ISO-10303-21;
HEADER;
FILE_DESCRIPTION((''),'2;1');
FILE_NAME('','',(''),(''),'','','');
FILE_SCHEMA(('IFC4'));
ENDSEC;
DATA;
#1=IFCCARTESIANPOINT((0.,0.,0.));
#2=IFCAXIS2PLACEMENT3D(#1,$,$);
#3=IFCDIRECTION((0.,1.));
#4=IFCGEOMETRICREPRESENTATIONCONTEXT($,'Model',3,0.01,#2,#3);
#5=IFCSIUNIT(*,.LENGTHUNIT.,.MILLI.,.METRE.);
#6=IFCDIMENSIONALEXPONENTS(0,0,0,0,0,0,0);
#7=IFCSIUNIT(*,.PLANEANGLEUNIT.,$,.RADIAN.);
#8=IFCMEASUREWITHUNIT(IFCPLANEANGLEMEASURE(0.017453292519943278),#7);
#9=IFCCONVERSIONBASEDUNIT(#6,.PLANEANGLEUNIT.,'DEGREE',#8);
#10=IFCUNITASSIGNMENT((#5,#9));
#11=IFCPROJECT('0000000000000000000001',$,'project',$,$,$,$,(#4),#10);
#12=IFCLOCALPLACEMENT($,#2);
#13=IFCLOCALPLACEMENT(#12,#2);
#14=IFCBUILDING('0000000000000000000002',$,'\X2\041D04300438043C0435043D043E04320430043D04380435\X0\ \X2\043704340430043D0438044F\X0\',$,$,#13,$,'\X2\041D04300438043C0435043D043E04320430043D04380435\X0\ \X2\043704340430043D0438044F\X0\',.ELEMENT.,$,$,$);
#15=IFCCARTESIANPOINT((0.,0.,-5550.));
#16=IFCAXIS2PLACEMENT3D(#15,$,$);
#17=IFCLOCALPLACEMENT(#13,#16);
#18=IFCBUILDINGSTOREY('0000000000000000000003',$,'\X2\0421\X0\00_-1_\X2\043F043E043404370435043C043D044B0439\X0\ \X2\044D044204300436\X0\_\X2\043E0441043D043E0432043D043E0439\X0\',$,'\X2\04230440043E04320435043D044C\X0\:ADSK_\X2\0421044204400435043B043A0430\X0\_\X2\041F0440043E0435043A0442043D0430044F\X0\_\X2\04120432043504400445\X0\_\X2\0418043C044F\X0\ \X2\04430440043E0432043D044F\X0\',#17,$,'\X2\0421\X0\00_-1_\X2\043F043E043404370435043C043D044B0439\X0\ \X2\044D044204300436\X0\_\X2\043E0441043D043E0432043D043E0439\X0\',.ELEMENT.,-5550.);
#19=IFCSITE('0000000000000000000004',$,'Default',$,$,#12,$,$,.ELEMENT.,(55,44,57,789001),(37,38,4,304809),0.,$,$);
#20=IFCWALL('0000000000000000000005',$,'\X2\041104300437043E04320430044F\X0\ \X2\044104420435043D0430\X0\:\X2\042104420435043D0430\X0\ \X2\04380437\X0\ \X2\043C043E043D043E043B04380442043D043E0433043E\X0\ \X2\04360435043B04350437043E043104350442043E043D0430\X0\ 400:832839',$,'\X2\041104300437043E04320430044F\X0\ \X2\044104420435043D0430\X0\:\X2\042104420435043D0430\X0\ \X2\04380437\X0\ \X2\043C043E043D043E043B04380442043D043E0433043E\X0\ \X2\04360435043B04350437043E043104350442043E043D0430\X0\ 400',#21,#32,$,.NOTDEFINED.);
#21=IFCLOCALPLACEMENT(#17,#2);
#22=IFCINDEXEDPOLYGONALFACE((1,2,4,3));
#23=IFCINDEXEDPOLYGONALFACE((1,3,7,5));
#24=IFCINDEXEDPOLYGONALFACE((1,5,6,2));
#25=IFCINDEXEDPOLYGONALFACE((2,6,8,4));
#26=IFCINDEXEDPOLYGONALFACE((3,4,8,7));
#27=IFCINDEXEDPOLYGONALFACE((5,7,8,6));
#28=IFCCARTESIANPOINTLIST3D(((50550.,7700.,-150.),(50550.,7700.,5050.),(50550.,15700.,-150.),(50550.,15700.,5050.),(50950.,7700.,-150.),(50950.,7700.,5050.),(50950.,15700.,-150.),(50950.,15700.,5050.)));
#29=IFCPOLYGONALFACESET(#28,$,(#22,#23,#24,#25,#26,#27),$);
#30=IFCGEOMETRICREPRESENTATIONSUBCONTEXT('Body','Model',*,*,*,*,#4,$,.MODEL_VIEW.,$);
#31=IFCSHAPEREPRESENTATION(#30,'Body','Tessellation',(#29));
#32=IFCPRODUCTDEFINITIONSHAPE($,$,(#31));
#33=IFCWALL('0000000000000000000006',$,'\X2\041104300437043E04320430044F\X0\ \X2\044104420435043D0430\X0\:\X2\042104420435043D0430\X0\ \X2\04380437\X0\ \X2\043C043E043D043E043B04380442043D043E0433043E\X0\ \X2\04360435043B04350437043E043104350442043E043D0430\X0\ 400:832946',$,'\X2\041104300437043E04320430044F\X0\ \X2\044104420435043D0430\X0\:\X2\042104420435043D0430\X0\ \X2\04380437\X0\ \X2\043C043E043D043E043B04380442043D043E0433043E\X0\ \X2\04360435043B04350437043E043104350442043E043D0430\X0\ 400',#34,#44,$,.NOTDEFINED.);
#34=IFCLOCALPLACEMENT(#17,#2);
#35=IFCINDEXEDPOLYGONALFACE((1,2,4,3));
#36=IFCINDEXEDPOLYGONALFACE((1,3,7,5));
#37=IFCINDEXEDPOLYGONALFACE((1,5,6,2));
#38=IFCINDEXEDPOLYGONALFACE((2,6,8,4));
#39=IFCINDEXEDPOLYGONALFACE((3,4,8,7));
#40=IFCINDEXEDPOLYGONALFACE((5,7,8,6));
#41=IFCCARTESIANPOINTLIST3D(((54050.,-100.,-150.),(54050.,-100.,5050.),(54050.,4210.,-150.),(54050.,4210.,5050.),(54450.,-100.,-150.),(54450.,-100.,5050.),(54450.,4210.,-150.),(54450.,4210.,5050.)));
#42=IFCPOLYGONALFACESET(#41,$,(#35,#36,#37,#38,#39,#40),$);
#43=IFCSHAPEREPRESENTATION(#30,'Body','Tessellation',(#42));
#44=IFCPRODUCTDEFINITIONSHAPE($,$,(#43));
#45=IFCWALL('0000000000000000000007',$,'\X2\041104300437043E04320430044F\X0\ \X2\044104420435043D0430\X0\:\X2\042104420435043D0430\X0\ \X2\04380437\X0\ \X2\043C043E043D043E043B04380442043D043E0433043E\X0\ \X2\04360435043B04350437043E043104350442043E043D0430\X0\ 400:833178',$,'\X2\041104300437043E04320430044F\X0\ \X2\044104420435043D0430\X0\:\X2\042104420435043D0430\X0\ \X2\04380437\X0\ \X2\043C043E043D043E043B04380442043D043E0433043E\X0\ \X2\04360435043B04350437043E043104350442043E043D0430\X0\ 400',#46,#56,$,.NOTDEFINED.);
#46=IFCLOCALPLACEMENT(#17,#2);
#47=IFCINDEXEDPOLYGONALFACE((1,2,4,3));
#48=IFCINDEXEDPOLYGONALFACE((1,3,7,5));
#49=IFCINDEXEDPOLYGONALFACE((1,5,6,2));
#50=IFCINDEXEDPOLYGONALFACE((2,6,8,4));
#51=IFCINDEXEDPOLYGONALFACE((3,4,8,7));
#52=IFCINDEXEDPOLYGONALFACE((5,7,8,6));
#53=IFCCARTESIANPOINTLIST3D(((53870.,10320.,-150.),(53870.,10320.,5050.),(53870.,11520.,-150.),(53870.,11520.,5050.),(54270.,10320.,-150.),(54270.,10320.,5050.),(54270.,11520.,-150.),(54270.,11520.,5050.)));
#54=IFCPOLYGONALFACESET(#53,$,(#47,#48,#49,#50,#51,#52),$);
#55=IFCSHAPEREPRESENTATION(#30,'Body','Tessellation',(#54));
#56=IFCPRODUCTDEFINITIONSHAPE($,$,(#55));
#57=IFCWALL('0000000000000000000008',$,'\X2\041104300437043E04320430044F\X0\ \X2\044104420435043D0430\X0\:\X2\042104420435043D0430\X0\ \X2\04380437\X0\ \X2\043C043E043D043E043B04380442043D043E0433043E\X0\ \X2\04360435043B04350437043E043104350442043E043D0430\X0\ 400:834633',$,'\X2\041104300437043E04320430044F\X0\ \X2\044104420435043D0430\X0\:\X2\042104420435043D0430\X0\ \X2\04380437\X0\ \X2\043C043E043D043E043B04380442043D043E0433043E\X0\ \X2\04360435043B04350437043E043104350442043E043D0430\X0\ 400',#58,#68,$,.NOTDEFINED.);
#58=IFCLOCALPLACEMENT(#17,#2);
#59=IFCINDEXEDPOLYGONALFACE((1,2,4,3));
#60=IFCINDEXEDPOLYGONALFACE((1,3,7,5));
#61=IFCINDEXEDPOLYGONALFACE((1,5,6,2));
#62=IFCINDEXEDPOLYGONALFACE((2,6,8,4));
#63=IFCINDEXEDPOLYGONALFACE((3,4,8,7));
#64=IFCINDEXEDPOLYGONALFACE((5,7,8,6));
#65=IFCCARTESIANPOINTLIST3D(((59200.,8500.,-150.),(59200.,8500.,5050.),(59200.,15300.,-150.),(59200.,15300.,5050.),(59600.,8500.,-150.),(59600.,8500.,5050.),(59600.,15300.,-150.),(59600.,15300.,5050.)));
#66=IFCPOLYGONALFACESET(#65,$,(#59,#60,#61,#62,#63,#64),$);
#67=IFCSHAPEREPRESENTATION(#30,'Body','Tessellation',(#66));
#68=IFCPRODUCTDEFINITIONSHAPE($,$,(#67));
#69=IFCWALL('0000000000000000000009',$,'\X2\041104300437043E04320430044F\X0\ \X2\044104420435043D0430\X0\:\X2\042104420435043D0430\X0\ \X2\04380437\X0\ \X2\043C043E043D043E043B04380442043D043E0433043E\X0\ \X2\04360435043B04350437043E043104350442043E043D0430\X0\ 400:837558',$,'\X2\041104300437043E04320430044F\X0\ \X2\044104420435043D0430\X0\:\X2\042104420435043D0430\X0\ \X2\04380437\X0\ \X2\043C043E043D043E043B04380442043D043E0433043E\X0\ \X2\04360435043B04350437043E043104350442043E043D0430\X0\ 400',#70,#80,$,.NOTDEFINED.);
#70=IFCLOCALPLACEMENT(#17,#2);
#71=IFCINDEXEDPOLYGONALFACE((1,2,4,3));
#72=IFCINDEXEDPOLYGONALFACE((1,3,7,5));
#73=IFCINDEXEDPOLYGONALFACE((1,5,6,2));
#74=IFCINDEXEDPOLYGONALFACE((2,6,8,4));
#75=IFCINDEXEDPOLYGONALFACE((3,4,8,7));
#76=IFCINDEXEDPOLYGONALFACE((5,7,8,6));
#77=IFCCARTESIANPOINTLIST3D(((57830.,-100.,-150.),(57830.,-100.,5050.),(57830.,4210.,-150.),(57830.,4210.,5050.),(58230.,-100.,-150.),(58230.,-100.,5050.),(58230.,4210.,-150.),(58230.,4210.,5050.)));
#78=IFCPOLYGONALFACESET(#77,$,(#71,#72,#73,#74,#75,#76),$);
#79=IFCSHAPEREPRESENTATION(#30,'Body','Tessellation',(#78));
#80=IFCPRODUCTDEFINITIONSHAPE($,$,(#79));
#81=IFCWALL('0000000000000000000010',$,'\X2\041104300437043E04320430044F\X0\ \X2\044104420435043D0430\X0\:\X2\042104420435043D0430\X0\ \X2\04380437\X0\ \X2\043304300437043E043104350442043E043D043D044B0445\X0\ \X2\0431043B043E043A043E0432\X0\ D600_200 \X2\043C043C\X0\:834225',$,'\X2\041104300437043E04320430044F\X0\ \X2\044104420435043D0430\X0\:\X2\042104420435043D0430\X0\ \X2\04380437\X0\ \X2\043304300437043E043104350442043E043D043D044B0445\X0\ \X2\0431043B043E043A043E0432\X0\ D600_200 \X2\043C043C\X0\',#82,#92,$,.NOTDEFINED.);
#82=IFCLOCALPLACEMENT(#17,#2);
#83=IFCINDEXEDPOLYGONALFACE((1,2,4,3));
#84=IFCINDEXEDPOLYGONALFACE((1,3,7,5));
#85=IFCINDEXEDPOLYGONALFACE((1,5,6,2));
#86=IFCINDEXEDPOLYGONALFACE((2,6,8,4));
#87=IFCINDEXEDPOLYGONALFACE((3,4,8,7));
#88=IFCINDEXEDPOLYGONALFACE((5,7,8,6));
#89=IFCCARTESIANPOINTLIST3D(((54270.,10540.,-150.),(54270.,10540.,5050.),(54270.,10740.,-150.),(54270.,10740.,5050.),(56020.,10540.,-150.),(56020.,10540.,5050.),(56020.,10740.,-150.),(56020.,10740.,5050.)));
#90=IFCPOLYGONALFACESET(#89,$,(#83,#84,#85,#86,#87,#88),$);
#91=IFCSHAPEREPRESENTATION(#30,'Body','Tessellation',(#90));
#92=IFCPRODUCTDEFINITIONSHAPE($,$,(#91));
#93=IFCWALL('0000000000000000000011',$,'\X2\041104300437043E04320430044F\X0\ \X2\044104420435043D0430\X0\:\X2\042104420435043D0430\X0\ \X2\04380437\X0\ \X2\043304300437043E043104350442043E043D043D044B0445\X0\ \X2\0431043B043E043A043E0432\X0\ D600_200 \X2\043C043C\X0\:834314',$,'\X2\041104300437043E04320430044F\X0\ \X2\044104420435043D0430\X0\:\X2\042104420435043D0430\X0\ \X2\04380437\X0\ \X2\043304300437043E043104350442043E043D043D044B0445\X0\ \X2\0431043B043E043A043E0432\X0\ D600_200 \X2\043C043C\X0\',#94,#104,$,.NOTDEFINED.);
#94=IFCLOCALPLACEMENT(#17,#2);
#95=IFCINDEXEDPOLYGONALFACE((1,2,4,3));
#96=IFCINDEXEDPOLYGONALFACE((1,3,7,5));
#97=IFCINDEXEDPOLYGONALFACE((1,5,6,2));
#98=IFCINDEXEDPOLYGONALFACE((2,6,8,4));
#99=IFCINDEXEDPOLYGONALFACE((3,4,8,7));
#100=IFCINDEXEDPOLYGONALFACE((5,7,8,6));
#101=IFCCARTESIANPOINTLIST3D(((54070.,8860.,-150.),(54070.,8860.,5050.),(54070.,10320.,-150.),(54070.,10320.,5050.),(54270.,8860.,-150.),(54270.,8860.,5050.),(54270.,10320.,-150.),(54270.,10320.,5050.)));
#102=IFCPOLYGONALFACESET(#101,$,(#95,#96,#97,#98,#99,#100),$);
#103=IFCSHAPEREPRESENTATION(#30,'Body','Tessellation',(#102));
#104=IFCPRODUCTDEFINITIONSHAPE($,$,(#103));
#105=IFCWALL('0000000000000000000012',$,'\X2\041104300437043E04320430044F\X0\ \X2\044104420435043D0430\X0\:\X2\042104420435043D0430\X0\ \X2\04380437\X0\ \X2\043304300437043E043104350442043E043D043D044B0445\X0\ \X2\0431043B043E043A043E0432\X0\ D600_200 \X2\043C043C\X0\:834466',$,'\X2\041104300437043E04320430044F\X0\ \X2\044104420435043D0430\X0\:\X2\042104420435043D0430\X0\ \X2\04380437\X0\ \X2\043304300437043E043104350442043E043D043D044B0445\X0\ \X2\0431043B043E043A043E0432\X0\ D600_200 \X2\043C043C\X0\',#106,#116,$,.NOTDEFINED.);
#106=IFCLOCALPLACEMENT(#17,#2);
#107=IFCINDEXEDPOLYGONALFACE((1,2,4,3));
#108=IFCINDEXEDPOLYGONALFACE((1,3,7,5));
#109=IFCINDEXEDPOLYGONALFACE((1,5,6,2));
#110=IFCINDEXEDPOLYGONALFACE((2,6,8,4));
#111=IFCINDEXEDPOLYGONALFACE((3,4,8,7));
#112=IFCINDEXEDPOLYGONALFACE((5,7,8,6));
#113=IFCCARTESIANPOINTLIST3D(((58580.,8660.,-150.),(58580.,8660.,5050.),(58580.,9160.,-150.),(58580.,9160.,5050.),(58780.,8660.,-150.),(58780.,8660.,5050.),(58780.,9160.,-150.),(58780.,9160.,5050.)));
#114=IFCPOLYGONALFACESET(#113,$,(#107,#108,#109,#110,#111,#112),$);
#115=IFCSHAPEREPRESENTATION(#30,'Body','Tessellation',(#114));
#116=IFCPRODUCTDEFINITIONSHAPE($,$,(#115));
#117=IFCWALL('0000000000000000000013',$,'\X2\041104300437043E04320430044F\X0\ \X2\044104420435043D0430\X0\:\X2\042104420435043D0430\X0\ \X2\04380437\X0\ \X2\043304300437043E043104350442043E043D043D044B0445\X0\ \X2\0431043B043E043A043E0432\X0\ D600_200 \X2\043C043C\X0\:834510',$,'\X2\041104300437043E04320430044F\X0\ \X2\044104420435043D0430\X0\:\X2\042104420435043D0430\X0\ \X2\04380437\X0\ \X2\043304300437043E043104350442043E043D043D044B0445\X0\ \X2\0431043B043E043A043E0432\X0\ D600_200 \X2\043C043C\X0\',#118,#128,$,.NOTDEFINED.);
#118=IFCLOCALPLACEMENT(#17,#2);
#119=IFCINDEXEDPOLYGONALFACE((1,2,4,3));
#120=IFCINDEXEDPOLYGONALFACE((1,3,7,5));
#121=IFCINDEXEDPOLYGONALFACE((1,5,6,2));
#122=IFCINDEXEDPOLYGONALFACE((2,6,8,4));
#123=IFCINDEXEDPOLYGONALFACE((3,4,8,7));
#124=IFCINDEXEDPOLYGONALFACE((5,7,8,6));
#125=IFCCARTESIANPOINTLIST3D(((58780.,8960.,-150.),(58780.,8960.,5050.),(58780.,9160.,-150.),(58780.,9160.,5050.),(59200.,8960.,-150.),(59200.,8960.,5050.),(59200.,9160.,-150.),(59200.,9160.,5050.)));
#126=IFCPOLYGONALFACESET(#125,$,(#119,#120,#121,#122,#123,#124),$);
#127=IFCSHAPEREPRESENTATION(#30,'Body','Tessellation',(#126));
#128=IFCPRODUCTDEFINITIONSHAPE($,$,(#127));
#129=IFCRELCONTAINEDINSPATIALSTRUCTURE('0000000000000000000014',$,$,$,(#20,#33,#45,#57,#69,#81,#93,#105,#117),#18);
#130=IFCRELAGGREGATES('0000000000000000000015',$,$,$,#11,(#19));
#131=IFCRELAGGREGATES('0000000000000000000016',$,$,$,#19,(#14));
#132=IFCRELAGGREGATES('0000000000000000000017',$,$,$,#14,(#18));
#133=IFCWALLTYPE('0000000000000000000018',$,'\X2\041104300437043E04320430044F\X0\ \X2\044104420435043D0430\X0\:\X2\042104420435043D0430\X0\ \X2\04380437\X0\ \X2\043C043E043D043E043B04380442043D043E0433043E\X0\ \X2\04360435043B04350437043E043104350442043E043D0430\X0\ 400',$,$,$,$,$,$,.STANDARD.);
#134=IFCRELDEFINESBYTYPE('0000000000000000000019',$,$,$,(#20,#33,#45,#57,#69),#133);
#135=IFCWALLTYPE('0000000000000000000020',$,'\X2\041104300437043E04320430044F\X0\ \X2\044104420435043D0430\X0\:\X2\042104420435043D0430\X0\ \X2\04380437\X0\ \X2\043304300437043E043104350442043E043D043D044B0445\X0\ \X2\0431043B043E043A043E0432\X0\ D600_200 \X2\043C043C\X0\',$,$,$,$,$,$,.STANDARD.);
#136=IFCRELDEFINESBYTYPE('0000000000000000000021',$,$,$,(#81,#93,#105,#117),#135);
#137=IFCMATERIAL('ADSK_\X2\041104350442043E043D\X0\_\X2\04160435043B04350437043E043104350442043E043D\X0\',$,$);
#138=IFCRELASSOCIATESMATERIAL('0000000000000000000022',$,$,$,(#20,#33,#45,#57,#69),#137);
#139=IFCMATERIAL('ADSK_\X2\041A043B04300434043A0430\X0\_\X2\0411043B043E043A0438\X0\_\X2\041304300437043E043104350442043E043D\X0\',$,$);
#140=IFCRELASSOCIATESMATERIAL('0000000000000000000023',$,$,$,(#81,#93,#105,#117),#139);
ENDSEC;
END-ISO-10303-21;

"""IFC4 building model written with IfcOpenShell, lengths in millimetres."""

from ifc_helpers import new_model, entity, si_unit, converted_unit, direction, frame, origin, place, context, subcontext, project, spatial, indexed_curve, outline, extrude, material, type_object, element, save


model = new_model("IFC4")

# Units and contexts
model_context = context("Model", 3, precision=0.01, world=origin(), true_north=direction((0.0, 1.0)))
body_context = subcontext(model_context, "Body", "Model", "MODEL_VIEW")
ifc_project = project(units=[si_unit("LENGTHUNIT", "METRE", prefix="MILLI"), converted_unit("PLANEANGLEUNIT", "DEGREE", entity("IfcPlaneAngleMeasure", 0.017453292519943278), si_unit("PLANEANGLEUNIT", "RADIAN"), dimensions=[0, 0, 0, 0, 0, 0, 0])], contexts=[model_context])

# Site, building, storey
site_placement = place(None, origin())
site = spatial("IfcSite", under=ifc_project, at=site_placement, Name="Default", CompositionType="ELEMENT", RefLatitude=(55, 44, 57, 789001), RefLongitude=(37, 38, 4, 304809), RefElevation=0.0)
building_placement = place(site_placement, origin())
building = spatial("IfcBuilding", under=site, at=building_placement, Name="Наименование здания", LongName="Наименование здания", CompositionType="ELEMENT")
storey_placement = place(building_placement, frame((0.0, 0.0, -5550.0)))
storey = spatial("IfcBuildingStorey", under=building, at=storey_placement, Name="С00_-1_подземный этаж_основной", ObjectType="Уровень:ADSK_Стрелка_Проектная_Вверх_Имя уровня", LongName="С00_-1_подземный этаж_основной", CompositionType="ELEMENT", Elevation=-5550.0)

# Shared definitions
ifc_material_1 = material(Name="ADSK_Бетон_Железобетон")

# Walls
wall_type_1 = type_object("IfcWallType", Name="Базовая стена:Стена из монолитного железобетона 400", PredefinedType="STANDARD")
wall_1_placement = place(storey_placement, frame((50750.0, 7700.0, -150.0), z_axis=(0.0, 0.0, 1.0), x_axis=(0.0, 1.0, 0.0)))
element("IfcWall", 1, at=wall_1_placement, inside=storey, type_object=wall_type_1, material=ifc_material_1, Name="Базовая стена:Стена из монолитного железобетона 400:832839", ObjectType="Базовая стена:Стена из монолитного железобетона 400", PredefinedType="NOTDEFINED", context=body_context, shape_type="SweptSolid", body=[
    extrude(outline(indexed_curve([(8000.0, 200.0), (0.0, 200.0), (0.0, -200.0), (8000.0, -200.0), (8000.0, 200.0)], self_intersect=False)), origin(), (0.0, 0.0, 1.0), 5200.0),
])
wall_2_placement = place(storey_placement, frame((54250.0, -100.0, -150.0), z_axis=(0.0, 0.0, 1.0), x_axis=(0.0, 1.0, 0.0)))
element("IfcWall", 2, at=wall_2_placement, inside=storey, type_object=wall_type_1, material=ifc_material_1, Name="Базовая стена:Стена из монолитного железобетона 400:832946", ObjectType="Базовая стена:Стена из монолитного железобетона 400", PredefinedType="NOTDEFINED", context=body_context, shape_type="SweptSolid", body=[
    extrude(outline(indexed_curve([(4310.0, 200.0), (0.0, 200.0), (0.0, -200.0), (4310.0, -200.0), (4310.0, 200.0)], self_intersect=False)), origin(), (0.0, 0.0, 1.0), 5200.0),
])
wall_3_placement = place(storey_placement, frame((54070.0, 10320.0, -150.0), z_axis=(0.0, 0.0, 1.0), x_axis=(0.0, 1.0, 0.0)))
element("IfcWall", 3, at=wall_3_placement, inside=storey, type_object=wall_type_1, material=ifc_material_1, Name="Базовая стена:Стена из монолитного железобетона 400:833178", ObjectType="Базовая стена:Стена из монолитного железобетона 400", PredefinedType="NOTDEFINED", context=body_context, shape_type="SweptSolid", body=[
    extrude(outline(indexed_curve([(1200.0, 200.0), (0.0, 200.0), (0.0, -200.0), (1200.0, -200.0), (1200.0, 200.0)], self_intersect=False)), origin(), (0.0, 0.0, 1.0), 5200.0),
])
wall_4_placement = place(storey_placement, frame((59400.0, 8500.0, -150.0), z_axis=(0.0, 0.0, 1.0), x_axis=(0.0, 1.0, 0.0)))
element("IfcWall", 4, at=wall_4_placement, inside=storey, type_object=wall_type_1, material=ifc_material_1, Name="Базовая стена:Стена из монолитного железобетона 400:834633", ObjectType="Базовая стена:Стена из монолитного железобетона 400", PredefinedType="NOTDEFINED", context=body_context, shape_type="SweptSolid", body=[
    extrude(outline(indexed_curve([(6800.0, 200.0), (0.0, 200.0), (0.0, -200.0), (6800.0, -200.0), (6800.0, 200.0)], self_intersect=False)), origin(), (0.0, 0.0, 1.0), 5200.0),
])
wall_5_placement = place(storey_placement, frame((58030.0, 4210.0, -150.0), z_axis=(0.0, 0.0, 1.0), x_axis=(0.0, -1.0, 0.0)))
element("IfcWall", 5, at=wall_5_placement, inside=storey, type_object=wall_type_1, material=ifc_material_1, Name="Базовая стена:Стена из монолитного железобетона 400:837558", ObjectType="Базовая стена:Стена из монолитного железобетона 400", PredefinedType="NOTDEFINED", context=body_context, shape_type="SweptSolid", body=[
    extrude(outline(indexed_curve([(4310.0, 200.0), (0.0, 200.0), (0.0, -200.0), (4310.0, -200.0), (4310.0, 200.0)], self_intersect=False)), origin(), (0.0, 0.0, 1.0), 5200.0),
])
ifc_material_2 = material(Name="ADSK_Кладка_Блоки_Газобетон")
wall_type_2 = type_object("IfcWallType", Name="Базовая стена:Стена из газобетонных блоков D600_200 мм", PredefinedType="STANDARD")
wall_6_placement = place(storey_placement, frame((56020.0, 10640.0, -150.0), z_axis=(0.0, 0.0, 1.0), x_axis=(-1.0, 0.0, 0.0)))
element("IfcWall", 6, at=wall_6_placement, inside=storey, type_object=wall_type_2, material=ifc_material_2, Name="Базовая стена:Стена из газобетонных блоков D600_200 мм:834225", ObjectType="Базовая стена:Стена из газобетонных блоков D600_200 мм", PredefinedType="NOTDEFINED", context=body_context, shape_type="SweptSolid", body=[
    extrude(outline(indexed_curve([(1750.0, 100.0), (0.0, 100.0), (0.0, -100.0), (1750.0, -100.0), (1750.0, 100.0)], self_intersect=False)), origin(), (0.0, 0.0, 1.0), 5200.0),
])
wall_7_placement = place(storey_placement, frame((54170.0, 10320.0, -150.0), z_axis=(0.0, 0.0, 1.0), x_axis=(0.0, -1.0, 0.0)))
element("IfcWall", 7, at=wall_7_placement, inside=storey, type_object=wall_type_2, material=ifc_material_2, Name="Базовая стена:Стена из газобетонных блоков D600_200 мм:834314", ObjectType="Базовая стена:Стена из газобетонных блоков D600_200 мм", PredefinedType="NOTDEFINED", context=body_context, shape_type="SweptSolid", body=[
    extrude(outline(indexed_curve([(1460.0, 100.0), (0.0, 100.0), (0.0, -100.0), (1460.0, -100.0), (1460.0, 100.0)], self_intersect=False)), origin(), (0.0, 0.0, 1.0), 5200.0),
])
wall_8_placement = place(storey_placement, frame((58680.0, 8660.0, -150.0), z_axis=(0.0, 0.0, 1.0), x_axis=(0.0, 1.0, 0.0)))
element("IfcWall", 8, at=wall_8_placement, inside=storey, type_object=wall_type_2, material=ifc_material_2, Name="Базовая стена:Стена из газобетонных блоков D600_200 мм:834466", ObjectType="Базовая стена:Стена из газобетонных блоков D600_200 мм", PredefinedType="NOTDEFINED", context=body_context, shape_type="SweptSolid", body=[
    extrude(outline(indexed_curve([(500.0, 100.0), (0.0, 100.0), (0.0, -100.0), (500.0, -100.0), (500.0, 100.0)], self_intersect=False)), origin(), (0.0, 0.0, 1.0), 5200.0),
])
wall_9_placement = place(storey_placement, frame((58780.0, 9060.0, -150.0)))
element("IfcWall", 9, at=wall_9_placement, inside=storey, type_object=wall_type_2, material=ifc_material_2, Name="Базовая стена:Стена из газобетонных блоков D600_200 мм:834510", ObjectType="Базовая стена:Стена из газобетонных блоков D600_200 мм", PredefinedType="NOTDEFINED", context=body_context, shape_type="SweptSolid", body=[
    extrude(outline(indexed_curve([(420.0, 100.0), (0.0, 100.0), (0.0, -100.0), (420.0, -100.0), (420.0, 100.0)], self_intersect=False)), origin(), (0.0, 0.0, 1.0), 5200.0),
])

save(model, "model.ifc")
